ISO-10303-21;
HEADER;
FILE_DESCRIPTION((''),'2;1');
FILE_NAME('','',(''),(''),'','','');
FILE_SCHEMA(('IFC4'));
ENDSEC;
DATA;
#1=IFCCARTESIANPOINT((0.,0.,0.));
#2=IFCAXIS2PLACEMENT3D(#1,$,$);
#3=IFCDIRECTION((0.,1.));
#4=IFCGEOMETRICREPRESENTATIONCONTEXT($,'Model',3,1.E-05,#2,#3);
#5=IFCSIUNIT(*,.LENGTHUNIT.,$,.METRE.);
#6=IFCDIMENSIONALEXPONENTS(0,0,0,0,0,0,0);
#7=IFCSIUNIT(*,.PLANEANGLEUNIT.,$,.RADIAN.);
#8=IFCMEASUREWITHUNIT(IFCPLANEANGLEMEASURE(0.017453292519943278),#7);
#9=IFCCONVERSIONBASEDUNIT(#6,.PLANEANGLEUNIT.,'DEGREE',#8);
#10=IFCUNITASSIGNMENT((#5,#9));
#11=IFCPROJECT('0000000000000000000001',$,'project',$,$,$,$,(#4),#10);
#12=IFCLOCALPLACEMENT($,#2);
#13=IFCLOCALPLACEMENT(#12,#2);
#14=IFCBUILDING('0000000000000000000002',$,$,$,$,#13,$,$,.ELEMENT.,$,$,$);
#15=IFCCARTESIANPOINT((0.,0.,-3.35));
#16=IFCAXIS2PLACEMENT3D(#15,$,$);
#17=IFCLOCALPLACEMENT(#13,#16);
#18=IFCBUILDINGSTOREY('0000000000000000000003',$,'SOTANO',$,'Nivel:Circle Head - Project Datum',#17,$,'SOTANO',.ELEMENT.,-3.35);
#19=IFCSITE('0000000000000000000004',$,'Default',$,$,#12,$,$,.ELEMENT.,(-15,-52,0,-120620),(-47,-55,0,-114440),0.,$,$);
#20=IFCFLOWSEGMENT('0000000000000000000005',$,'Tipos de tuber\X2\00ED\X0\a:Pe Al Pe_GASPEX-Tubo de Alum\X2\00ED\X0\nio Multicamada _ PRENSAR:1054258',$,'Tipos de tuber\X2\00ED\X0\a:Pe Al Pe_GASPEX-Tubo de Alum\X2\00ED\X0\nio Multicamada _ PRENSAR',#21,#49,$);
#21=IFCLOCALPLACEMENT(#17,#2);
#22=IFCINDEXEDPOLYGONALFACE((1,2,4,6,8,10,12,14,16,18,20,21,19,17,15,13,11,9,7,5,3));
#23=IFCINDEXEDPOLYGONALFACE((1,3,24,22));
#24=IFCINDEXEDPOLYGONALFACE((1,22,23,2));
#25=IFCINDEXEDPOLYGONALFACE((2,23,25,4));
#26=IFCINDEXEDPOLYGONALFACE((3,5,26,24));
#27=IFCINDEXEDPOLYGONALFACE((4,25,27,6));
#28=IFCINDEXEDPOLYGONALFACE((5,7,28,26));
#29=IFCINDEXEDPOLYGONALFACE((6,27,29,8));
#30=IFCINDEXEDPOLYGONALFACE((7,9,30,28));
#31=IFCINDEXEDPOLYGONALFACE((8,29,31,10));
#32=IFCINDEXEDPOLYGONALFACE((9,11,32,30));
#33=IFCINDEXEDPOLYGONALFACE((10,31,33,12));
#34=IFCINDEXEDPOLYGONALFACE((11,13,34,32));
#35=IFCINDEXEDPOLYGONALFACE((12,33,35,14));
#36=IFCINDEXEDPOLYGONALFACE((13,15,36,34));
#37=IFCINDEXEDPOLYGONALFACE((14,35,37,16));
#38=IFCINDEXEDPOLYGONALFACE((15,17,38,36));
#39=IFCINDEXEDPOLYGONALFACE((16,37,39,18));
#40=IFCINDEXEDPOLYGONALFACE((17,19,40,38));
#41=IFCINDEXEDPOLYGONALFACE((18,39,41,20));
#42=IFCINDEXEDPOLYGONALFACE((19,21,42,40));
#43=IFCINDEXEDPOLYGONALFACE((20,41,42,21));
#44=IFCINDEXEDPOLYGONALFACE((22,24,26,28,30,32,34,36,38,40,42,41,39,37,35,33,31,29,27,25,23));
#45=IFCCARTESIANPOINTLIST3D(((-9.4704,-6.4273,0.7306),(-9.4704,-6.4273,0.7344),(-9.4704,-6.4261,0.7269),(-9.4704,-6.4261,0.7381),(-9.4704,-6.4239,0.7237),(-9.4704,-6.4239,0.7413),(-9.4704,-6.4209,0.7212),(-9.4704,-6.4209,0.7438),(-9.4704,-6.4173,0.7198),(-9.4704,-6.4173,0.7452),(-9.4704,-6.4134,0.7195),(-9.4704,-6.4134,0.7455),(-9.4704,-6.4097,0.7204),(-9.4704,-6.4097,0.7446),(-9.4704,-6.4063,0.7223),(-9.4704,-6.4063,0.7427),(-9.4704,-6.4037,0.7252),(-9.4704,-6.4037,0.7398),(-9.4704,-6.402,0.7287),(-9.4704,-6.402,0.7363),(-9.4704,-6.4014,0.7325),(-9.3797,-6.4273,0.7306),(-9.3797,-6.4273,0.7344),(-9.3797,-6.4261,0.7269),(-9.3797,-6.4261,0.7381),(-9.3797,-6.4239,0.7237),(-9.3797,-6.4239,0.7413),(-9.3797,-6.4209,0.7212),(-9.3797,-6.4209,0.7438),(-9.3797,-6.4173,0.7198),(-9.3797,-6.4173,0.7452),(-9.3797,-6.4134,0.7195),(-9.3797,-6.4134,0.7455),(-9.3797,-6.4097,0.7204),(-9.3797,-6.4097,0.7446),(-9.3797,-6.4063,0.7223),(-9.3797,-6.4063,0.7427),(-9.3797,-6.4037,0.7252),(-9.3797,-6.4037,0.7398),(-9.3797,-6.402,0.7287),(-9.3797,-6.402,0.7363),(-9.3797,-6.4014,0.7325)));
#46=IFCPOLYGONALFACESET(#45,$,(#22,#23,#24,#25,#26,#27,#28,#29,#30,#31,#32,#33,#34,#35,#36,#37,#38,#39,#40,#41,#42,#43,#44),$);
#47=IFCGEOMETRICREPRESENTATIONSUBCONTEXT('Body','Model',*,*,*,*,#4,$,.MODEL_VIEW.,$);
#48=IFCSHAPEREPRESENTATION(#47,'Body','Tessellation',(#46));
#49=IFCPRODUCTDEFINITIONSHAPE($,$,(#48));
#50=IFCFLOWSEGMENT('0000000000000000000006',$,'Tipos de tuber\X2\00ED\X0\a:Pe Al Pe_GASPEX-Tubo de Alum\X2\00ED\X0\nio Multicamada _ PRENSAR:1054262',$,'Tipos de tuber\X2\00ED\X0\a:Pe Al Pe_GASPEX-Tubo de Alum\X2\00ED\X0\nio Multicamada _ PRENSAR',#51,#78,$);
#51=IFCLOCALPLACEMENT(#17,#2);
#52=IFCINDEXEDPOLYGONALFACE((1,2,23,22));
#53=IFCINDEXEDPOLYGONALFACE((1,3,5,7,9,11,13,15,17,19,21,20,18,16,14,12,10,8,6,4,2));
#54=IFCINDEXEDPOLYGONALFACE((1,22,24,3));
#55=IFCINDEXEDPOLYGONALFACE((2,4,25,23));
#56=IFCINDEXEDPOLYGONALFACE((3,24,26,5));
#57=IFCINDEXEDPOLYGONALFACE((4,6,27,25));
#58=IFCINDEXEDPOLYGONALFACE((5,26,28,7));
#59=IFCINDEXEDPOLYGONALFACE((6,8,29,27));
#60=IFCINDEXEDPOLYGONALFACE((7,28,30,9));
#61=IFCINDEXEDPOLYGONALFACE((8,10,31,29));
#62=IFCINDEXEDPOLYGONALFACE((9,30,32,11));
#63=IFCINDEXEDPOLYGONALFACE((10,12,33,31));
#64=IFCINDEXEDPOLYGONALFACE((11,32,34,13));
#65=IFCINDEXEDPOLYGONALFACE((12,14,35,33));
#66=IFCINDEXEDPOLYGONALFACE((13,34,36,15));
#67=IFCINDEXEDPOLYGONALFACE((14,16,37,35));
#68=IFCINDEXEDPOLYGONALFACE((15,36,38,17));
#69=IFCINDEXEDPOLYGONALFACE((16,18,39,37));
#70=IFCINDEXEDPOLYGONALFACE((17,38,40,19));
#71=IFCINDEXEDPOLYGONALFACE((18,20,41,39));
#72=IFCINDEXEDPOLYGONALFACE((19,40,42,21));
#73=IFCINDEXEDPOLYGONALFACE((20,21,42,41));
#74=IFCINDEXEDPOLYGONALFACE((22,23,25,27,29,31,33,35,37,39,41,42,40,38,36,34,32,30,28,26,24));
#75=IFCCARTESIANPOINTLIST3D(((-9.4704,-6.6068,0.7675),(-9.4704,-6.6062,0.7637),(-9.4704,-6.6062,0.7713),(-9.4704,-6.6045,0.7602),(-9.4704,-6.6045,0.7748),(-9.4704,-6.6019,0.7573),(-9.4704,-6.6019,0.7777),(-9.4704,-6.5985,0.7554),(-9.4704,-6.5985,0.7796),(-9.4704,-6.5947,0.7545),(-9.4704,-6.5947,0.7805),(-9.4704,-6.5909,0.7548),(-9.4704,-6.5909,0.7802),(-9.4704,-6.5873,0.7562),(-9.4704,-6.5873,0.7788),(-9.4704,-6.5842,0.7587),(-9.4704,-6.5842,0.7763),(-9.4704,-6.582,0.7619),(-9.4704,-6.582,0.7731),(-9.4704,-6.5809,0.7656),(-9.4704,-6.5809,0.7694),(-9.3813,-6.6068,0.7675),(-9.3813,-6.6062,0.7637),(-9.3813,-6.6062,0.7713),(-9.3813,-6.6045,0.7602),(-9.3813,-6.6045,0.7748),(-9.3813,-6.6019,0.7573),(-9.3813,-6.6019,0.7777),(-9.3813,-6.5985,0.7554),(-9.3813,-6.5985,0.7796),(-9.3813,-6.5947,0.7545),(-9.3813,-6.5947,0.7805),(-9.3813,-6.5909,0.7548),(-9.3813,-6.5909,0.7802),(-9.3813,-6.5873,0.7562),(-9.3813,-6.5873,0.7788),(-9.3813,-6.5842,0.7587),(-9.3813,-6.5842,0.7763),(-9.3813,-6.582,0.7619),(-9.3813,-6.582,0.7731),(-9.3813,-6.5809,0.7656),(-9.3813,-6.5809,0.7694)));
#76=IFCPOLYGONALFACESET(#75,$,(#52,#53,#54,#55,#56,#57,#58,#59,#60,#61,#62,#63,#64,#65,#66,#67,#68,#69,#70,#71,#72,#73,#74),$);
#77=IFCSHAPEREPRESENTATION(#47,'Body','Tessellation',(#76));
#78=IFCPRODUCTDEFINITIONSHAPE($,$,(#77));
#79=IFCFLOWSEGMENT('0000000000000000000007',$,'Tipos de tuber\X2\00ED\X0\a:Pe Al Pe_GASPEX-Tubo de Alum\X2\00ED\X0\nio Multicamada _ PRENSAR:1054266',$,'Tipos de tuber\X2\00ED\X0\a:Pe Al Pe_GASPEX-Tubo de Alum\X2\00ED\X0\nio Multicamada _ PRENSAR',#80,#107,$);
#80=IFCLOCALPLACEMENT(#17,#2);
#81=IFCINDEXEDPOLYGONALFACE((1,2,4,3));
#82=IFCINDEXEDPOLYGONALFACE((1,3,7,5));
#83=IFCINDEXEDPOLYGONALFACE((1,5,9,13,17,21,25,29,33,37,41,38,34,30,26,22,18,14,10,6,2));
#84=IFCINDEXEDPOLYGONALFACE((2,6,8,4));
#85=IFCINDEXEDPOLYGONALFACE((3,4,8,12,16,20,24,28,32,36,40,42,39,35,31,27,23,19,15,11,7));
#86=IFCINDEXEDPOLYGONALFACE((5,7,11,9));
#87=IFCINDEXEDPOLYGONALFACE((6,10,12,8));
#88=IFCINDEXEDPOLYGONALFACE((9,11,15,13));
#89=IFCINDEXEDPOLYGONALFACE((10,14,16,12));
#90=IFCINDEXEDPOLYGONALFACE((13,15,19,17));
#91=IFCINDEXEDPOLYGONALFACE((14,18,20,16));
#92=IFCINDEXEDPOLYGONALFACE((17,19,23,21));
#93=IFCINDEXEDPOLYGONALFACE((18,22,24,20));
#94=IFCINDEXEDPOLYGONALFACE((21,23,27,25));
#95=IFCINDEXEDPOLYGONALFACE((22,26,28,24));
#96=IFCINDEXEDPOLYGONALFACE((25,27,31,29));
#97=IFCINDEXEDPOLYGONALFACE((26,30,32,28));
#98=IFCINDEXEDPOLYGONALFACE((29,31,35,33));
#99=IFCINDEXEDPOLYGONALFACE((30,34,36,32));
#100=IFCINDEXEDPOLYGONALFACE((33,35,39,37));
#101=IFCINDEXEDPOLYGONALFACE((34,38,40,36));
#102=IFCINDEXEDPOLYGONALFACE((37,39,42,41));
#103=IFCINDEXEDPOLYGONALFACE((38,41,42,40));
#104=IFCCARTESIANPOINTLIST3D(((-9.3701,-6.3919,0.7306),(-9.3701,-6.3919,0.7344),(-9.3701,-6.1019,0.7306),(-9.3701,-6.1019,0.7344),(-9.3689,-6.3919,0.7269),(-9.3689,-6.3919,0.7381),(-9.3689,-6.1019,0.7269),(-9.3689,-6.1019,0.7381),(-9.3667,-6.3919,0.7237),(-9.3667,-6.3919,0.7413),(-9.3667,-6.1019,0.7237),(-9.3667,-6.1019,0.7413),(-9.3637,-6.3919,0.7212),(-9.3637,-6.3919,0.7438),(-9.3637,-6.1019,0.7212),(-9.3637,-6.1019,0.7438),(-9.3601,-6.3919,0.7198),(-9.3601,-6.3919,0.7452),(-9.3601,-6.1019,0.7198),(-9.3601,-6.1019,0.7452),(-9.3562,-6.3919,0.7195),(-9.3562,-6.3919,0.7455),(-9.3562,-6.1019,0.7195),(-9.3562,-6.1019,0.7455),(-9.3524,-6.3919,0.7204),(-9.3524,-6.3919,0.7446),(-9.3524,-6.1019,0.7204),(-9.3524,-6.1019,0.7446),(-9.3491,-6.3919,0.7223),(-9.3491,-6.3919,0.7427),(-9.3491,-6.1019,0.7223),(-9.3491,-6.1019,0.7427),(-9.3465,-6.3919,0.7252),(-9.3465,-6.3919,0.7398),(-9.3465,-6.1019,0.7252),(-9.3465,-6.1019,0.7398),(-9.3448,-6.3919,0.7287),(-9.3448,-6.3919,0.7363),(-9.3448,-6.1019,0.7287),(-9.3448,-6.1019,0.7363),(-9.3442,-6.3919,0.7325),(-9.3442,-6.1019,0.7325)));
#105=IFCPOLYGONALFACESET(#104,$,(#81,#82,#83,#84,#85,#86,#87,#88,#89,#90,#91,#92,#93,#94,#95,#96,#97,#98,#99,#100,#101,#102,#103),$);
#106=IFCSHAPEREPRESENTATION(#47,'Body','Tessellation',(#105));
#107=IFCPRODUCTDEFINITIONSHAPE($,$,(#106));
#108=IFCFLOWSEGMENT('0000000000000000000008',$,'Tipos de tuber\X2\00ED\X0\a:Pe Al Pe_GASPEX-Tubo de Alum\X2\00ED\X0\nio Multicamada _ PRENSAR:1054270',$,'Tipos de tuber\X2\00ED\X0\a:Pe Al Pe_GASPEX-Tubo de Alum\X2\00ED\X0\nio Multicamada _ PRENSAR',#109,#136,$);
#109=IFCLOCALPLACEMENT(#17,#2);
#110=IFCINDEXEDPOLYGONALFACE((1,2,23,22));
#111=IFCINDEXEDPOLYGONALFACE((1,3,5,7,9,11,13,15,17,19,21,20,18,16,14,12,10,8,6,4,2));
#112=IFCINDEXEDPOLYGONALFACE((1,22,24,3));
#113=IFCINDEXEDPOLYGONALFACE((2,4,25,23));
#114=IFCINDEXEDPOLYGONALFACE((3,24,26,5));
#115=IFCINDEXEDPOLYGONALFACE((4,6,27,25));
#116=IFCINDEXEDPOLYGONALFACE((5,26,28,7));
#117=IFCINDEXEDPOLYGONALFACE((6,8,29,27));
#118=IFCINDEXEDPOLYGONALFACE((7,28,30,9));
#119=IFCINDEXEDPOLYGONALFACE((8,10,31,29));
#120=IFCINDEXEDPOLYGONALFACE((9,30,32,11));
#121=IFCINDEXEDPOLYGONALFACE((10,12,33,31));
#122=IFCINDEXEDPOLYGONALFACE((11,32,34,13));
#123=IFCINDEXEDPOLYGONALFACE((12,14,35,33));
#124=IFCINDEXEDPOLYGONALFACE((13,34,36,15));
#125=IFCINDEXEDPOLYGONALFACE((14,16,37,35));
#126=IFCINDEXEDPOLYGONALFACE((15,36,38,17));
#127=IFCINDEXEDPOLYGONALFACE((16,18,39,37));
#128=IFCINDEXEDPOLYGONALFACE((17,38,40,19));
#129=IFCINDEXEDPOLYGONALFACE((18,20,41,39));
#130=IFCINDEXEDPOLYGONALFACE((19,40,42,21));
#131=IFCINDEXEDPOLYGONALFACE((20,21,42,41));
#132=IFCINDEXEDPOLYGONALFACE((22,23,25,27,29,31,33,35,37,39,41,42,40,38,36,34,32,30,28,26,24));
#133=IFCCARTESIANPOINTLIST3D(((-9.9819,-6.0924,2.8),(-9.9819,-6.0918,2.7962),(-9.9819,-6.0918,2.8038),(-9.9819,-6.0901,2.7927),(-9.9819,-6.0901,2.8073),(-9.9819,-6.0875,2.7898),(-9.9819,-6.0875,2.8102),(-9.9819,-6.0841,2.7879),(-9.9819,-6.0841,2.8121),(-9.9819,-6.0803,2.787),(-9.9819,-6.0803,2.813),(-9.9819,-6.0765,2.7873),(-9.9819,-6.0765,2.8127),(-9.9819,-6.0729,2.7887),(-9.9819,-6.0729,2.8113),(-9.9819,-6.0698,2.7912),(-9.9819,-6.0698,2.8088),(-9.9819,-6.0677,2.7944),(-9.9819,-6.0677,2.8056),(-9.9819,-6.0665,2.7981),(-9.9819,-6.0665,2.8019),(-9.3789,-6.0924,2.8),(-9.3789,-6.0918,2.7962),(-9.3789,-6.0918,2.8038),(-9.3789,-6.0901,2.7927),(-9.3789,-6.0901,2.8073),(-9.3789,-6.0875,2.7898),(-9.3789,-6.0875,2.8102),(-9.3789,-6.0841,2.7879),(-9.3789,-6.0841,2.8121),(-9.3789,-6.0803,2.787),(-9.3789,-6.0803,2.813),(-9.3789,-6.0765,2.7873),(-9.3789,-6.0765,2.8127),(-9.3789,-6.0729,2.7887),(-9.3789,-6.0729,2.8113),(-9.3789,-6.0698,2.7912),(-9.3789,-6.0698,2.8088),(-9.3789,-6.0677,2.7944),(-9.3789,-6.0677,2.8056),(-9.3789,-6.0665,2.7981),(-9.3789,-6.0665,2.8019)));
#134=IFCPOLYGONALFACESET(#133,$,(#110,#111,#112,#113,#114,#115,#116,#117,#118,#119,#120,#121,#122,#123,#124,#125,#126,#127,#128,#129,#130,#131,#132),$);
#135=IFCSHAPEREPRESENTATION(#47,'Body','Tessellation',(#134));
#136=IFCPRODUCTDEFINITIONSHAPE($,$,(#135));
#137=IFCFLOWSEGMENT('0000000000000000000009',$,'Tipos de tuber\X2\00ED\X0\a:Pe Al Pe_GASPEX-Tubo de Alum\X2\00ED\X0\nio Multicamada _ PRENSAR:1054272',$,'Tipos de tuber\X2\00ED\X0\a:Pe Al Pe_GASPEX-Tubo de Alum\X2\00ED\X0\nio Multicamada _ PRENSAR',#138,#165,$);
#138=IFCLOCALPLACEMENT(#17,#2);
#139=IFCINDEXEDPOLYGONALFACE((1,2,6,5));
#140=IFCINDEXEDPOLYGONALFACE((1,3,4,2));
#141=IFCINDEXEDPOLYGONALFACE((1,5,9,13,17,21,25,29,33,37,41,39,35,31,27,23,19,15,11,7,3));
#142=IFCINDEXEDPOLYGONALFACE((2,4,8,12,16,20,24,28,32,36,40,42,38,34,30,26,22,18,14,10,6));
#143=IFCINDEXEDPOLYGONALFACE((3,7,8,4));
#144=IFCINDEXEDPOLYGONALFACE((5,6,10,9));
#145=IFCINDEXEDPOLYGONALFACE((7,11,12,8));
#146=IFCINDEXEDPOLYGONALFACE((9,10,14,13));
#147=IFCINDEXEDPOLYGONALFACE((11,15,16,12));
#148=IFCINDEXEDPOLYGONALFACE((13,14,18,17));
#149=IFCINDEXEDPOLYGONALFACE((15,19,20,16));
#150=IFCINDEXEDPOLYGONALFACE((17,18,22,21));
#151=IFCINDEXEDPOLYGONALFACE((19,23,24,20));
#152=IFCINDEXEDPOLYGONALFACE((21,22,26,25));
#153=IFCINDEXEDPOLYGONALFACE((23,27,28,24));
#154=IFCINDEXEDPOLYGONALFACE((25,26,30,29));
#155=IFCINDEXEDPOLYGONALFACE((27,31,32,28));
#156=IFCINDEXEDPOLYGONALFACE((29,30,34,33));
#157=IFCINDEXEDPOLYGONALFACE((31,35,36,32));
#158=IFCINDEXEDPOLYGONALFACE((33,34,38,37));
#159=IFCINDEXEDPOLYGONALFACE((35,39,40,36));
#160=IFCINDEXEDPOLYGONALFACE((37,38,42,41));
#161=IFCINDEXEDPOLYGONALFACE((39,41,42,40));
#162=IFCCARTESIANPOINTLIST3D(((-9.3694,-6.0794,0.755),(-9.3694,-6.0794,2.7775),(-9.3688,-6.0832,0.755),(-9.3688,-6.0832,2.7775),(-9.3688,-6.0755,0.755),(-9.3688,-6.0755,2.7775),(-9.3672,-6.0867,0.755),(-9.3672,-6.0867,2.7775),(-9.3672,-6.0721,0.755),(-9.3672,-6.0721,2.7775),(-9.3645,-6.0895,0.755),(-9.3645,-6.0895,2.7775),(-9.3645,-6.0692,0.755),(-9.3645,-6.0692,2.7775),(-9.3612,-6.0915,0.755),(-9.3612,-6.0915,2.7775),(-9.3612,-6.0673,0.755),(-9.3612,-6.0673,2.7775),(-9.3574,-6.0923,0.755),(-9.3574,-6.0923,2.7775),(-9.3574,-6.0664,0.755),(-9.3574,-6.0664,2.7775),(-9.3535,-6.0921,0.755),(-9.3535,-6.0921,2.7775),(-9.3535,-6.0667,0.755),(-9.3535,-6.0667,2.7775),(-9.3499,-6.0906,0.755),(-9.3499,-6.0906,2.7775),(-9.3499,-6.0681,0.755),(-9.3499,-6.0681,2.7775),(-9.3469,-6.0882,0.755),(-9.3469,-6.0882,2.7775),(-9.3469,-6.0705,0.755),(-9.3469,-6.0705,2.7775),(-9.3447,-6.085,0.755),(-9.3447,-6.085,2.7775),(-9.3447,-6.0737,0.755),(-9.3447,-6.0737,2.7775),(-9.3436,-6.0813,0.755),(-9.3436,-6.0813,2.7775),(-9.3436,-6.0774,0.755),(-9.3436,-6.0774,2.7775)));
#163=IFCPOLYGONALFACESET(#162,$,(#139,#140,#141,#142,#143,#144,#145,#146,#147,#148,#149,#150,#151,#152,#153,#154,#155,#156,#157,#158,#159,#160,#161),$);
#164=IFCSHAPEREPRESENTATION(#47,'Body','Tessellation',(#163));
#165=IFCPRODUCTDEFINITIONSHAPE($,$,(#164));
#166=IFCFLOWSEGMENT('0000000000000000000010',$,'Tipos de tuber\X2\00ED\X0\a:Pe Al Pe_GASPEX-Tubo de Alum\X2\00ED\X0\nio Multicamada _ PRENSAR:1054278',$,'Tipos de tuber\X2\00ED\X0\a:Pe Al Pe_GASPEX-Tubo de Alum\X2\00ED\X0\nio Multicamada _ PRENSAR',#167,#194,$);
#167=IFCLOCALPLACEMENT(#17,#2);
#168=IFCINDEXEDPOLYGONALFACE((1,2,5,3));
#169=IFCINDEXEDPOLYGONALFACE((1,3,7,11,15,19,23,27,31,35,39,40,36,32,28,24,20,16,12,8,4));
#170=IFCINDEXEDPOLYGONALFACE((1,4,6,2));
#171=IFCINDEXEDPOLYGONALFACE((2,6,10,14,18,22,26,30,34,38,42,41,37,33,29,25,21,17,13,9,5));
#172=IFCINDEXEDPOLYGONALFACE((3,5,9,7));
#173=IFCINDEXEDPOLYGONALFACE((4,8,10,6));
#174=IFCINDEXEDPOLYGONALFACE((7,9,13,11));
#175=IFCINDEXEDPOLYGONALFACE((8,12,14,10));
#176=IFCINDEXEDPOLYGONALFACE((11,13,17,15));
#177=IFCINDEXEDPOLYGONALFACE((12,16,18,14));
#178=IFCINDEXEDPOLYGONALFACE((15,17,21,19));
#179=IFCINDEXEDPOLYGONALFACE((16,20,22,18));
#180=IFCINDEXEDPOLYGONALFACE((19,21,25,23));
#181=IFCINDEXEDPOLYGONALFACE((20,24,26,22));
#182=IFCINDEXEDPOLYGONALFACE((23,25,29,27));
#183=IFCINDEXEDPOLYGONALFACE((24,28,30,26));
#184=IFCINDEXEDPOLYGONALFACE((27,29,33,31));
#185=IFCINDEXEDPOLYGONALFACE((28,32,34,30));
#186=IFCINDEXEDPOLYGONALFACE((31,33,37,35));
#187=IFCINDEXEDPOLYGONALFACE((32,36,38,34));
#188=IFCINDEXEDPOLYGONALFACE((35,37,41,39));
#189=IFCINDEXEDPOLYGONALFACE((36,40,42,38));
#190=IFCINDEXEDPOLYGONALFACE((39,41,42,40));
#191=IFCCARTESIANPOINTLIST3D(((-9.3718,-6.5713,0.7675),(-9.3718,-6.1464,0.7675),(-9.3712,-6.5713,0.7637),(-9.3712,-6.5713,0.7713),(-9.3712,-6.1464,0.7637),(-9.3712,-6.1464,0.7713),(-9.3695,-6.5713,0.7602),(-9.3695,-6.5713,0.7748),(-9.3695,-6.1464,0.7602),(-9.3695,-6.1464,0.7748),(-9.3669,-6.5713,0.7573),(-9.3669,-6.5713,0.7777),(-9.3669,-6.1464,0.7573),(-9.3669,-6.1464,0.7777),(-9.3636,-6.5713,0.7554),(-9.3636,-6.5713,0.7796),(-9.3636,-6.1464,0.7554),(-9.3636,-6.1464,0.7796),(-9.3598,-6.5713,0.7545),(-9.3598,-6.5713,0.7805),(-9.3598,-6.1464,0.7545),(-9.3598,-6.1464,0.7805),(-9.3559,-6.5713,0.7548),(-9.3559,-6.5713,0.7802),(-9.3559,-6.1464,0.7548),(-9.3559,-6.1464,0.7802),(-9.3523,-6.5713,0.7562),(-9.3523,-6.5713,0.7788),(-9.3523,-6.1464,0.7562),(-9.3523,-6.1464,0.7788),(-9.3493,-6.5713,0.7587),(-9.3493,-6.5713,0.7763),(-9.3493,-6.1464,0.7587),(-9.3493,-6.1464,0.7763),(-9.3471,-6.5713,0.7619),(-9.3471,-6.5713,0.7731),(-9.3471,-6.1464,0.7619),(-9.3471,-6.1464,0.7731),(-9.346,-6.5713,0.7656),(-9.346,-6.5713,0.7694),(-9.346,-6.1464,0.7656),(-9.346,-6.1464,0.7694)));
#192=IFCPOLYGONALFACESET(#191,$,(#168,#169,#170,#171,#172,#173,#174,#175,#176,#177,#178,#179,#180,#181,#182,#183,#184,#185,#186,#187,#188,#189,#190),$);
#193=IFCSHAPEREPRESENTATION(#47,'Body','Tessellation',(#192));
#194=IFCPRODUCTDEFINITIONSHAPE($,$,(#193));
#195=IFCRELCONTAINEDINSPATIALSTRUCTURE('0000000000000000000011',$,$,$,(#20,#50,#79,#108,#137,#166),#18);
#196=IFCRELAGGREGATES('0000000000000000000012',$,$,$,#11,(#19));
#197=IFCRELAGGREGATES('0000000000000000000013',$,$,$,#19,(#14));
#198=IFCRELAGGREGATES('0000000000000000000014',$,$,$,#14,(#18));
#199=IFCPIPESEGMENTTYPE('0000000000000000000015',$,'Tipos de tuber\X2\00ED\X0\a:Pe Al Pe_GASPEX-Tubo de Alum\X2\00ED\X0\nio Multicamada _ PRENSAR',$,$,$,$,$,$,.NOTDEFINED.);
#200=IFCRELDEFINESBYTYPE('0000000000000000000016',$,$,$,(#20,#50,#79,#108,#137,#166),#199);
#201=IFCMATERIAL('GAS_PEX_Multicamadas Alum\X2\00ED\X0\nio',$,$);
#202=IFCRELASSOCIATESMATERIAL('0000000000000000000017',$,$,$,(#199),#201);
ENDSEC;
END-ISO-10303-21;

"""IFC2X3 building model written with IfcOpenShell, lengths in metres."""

from ifc_helpers import new_model, entity, si_unit, converted_unit, direction, frame, frame_2d, origin, origin_2d_with_axis, place, context, subcontext, project, spatial, circle, extrude, material, type_object, element, save


model = new_model("IFC2X3")

# Units and contexts
model_context = context("Model", 3, precision=1e-05, world=origin(), true_north=direction((0.0, 1.0)))
body_context = subcontext(model_context, "Body", "Model", "MODEL_VIEW")
ifc_project = project(units=[si_unit("LENGTHUNIT", "METRE"), converted_unit("PLANEANGLEUNIT", "DEGREE", entity("IfcPlaneAngleMeasure", 0.017453292519943278), si_unit("PLANEANGLEUNIT", "RADIAN"), dimensions=[0, 0, 0, 0, 0, 0, 0])], contexts=[model_context])

# Site, building, storey
site_placement = place(None, origin())
site = spatial("IfcSite", under=ifc_project, at=site_placement, Name="Default", CompositionType="ELEMENT", RefLatitude=(-15, -52, 0, -120620), RefLongitude=(-47, -55, 0, -114440), RefElevation=0.0)
building_placement = place(site_placement, origin())
building = spatial("IfcBuilding", under=site, at=building_placement, CompositionType="ELEMENT")
storey_placement = place(building_placement, frame((0.0, 0.0, -3.35)))
storey = spatial("IfcBuildingStorey", under=building, at=storey_placement, Name="SOTANO", ObjectType="Nivel:Circle Head - Project Datum", LongName="SOTANO", CompositionType="ELEMENT", Elevation=-3.35)

# Flow segments
ifc_material = material(Name="GAS_PEX_Multicamadas Alumínio")
pipe_segment_type_1 = type_object("IfcPipeSegmentType", Name="Tipos de tubería:Pe Al Pe_GASPEX-Tubo de Alumínio Multicamada _ PRENSAR", PredefinedType="NOTDEFINED", material=ifc_material)
flow_segment_1_placement = place(storey_placement, origin())
element("IfcFlowSegment", 1, at=flow_segment_1_placement, inside=storey, type_object=pipe_segment_type_1, Name="Tipos de tubería:Pe Al Pe_GASPEX-Tubo de Alumínio Multicamada _ PRENSAR:1054258", ObjectType="Tipos de tubería:Pe Al Pe_GASPEX-Tubo de Alumínio Multicamada _ PRENSAR", context=body_context, shape_type="SweptSolid", body=[
    extrude(circle(Radius=0.013, at=origin_2d_with_axis()), frame((-9.4704, -6.4144, 0.7325), z_axis=(1.0, 0.0, 0.0), x_axis=(0.0, 1.0, 0.0)), (0.0, 0.0, 1.0), 0.0907),
])
flow_segment_2_placement = place(storey_placement, origin())
element("IfcFlowSegment", 2, at=flow_segment_2_placement, inside=storey, type_object=pipe_segment_type_1, Name="Tipos de tubería:Pe Al Pe_GASPEX-Tubo de Alumínio Multicamada _ PRENSAR:1054262", ObjectType="Tipos de tubería:Pe Al Pe_GASPEX-Tubo de Alumínio Multicamada _ PRENSAR", context=body_context, shape_type="SweptSolid", body=[
    extrude(circle(Radius=0.013, at=origin_2d_with_axis()), frame((-9.4704, -6.5938, 0.7675), z_axis=(1.0, 0.0, 0.0), x_axis=(0.0, -1.0, 0.0)), (0.0, 0.0, 1.0), 0.0891),
])
flow_segment_3_placement = place(storey_placement, origin())
element("IfcFlowSegment", 3, at=flow_segment_3_placement, inside=storey, type_object=pipe_segment_type_1, Name="Tipos de tubería:Pe Al Pe_GASPEX-Tubo de Alumínio Multicamada _ PRENSAR:1054266", ObjectType="Tipos de tubería:Pe Al Pe_GASPEX-Tubo de Alumínio Multicamada _ PRENSAR", context=body_context, shape_type="SweptSolid", body=[
    extrude(circle(Radius=0.013, at=frame_2d((0.0, 0.0), x_axis=(1.0, 0.0))), frame((-9.3572, -6.3919, 0.7325), z_axis=(0.0, 1.0, 0.0), x_axis=(1.0, 0.0, 0.0)), (0.0, 0.0, 1.0), 0.2901),
])
flow_segment_4_placement = place(storey_placement, origin())
element("IfcFlowSegment", 4, at=flow_segment_4_placement, inside=storey, type_object=pipe_segment_type_1, Name="Tipos de tubería:Pe Al Pe_GASPEX-Tubo de Alumínio Multicamada _ PRENSAR:1054270", ObjectType="Tipos de tubería:Pe Al Pe_GASPEX-Tubo de Alumínio Multicamada _ PRENSAR", context=body_context, shape_type="SweptSolid", body=[
    extrude(circle(Radius=0.013, at=origin_2d_with_axis()), frame((-9.9819, -6.0794, 2.8), z_axis=(1.0, 0.0, 0.0), x_axis=(0.0, -1.0, 0.0)), (0.0, 0.0, 1.0), 0.6029),
])
flow_segment_5_placement = place(storey_placement, origin())
element("IfcFlowSegment", 5, at=flow_segment_5_placement, inside=storey, type_object=pipe_segment_type_1, Name="Tipos de tubería:Pe Al Pe_GASPEX-Tubo de Alumínio Multicamada _ PRENSAR:1054272", ObjectType="Tipos de tubería:Pe Al Pe_GASPEX-Tubo de Alumínio Multicamada _ PRENSAR", context=body_context, shape_type="SweptSolid", body=[
    extrude(circle(Radius=0.013, at=origin_2d_with_axis()), frame((-9.3564, -6.0794, 0.755), z_axis=(0.0, 0.0, 1.0), x_axis=(-1.0, 0.0, 0.0)), (0.0, 0.0, 1.0), 2.0225),
])
flow_segment_6_placement = place(storey_placement, origin())
element("IfcFlowSegment", 6, at=flow_segment_6_placement, inside=storey, type_object=pipe_segment_type_1, Name="Tipos de tubería:Pe Al Pe_GASPEX-Tubo de Alumínio Multicamada _ PRENSAR:1054278", ObjectType="Tipos de tubería:Pe Al Pe_GASPEX-Tubo de Alumínio Multicamada _ PRENSAR", context=body_context, shape_type="SweptSolid", body=[
    extrude(circle(Radius=0.013, at=frame_2d((0.0, 0.0), x_axis=(1.0, 0.0))), frame((-9.3588, -6.5713, 0.7675), z_axis=(0.0, 1.0, 0.0), x_axis=(-1.0, 0.0, 0.0)), (0.0, 0.0, 1.0), 0.4248),
])

save(model, "model.ifc")
